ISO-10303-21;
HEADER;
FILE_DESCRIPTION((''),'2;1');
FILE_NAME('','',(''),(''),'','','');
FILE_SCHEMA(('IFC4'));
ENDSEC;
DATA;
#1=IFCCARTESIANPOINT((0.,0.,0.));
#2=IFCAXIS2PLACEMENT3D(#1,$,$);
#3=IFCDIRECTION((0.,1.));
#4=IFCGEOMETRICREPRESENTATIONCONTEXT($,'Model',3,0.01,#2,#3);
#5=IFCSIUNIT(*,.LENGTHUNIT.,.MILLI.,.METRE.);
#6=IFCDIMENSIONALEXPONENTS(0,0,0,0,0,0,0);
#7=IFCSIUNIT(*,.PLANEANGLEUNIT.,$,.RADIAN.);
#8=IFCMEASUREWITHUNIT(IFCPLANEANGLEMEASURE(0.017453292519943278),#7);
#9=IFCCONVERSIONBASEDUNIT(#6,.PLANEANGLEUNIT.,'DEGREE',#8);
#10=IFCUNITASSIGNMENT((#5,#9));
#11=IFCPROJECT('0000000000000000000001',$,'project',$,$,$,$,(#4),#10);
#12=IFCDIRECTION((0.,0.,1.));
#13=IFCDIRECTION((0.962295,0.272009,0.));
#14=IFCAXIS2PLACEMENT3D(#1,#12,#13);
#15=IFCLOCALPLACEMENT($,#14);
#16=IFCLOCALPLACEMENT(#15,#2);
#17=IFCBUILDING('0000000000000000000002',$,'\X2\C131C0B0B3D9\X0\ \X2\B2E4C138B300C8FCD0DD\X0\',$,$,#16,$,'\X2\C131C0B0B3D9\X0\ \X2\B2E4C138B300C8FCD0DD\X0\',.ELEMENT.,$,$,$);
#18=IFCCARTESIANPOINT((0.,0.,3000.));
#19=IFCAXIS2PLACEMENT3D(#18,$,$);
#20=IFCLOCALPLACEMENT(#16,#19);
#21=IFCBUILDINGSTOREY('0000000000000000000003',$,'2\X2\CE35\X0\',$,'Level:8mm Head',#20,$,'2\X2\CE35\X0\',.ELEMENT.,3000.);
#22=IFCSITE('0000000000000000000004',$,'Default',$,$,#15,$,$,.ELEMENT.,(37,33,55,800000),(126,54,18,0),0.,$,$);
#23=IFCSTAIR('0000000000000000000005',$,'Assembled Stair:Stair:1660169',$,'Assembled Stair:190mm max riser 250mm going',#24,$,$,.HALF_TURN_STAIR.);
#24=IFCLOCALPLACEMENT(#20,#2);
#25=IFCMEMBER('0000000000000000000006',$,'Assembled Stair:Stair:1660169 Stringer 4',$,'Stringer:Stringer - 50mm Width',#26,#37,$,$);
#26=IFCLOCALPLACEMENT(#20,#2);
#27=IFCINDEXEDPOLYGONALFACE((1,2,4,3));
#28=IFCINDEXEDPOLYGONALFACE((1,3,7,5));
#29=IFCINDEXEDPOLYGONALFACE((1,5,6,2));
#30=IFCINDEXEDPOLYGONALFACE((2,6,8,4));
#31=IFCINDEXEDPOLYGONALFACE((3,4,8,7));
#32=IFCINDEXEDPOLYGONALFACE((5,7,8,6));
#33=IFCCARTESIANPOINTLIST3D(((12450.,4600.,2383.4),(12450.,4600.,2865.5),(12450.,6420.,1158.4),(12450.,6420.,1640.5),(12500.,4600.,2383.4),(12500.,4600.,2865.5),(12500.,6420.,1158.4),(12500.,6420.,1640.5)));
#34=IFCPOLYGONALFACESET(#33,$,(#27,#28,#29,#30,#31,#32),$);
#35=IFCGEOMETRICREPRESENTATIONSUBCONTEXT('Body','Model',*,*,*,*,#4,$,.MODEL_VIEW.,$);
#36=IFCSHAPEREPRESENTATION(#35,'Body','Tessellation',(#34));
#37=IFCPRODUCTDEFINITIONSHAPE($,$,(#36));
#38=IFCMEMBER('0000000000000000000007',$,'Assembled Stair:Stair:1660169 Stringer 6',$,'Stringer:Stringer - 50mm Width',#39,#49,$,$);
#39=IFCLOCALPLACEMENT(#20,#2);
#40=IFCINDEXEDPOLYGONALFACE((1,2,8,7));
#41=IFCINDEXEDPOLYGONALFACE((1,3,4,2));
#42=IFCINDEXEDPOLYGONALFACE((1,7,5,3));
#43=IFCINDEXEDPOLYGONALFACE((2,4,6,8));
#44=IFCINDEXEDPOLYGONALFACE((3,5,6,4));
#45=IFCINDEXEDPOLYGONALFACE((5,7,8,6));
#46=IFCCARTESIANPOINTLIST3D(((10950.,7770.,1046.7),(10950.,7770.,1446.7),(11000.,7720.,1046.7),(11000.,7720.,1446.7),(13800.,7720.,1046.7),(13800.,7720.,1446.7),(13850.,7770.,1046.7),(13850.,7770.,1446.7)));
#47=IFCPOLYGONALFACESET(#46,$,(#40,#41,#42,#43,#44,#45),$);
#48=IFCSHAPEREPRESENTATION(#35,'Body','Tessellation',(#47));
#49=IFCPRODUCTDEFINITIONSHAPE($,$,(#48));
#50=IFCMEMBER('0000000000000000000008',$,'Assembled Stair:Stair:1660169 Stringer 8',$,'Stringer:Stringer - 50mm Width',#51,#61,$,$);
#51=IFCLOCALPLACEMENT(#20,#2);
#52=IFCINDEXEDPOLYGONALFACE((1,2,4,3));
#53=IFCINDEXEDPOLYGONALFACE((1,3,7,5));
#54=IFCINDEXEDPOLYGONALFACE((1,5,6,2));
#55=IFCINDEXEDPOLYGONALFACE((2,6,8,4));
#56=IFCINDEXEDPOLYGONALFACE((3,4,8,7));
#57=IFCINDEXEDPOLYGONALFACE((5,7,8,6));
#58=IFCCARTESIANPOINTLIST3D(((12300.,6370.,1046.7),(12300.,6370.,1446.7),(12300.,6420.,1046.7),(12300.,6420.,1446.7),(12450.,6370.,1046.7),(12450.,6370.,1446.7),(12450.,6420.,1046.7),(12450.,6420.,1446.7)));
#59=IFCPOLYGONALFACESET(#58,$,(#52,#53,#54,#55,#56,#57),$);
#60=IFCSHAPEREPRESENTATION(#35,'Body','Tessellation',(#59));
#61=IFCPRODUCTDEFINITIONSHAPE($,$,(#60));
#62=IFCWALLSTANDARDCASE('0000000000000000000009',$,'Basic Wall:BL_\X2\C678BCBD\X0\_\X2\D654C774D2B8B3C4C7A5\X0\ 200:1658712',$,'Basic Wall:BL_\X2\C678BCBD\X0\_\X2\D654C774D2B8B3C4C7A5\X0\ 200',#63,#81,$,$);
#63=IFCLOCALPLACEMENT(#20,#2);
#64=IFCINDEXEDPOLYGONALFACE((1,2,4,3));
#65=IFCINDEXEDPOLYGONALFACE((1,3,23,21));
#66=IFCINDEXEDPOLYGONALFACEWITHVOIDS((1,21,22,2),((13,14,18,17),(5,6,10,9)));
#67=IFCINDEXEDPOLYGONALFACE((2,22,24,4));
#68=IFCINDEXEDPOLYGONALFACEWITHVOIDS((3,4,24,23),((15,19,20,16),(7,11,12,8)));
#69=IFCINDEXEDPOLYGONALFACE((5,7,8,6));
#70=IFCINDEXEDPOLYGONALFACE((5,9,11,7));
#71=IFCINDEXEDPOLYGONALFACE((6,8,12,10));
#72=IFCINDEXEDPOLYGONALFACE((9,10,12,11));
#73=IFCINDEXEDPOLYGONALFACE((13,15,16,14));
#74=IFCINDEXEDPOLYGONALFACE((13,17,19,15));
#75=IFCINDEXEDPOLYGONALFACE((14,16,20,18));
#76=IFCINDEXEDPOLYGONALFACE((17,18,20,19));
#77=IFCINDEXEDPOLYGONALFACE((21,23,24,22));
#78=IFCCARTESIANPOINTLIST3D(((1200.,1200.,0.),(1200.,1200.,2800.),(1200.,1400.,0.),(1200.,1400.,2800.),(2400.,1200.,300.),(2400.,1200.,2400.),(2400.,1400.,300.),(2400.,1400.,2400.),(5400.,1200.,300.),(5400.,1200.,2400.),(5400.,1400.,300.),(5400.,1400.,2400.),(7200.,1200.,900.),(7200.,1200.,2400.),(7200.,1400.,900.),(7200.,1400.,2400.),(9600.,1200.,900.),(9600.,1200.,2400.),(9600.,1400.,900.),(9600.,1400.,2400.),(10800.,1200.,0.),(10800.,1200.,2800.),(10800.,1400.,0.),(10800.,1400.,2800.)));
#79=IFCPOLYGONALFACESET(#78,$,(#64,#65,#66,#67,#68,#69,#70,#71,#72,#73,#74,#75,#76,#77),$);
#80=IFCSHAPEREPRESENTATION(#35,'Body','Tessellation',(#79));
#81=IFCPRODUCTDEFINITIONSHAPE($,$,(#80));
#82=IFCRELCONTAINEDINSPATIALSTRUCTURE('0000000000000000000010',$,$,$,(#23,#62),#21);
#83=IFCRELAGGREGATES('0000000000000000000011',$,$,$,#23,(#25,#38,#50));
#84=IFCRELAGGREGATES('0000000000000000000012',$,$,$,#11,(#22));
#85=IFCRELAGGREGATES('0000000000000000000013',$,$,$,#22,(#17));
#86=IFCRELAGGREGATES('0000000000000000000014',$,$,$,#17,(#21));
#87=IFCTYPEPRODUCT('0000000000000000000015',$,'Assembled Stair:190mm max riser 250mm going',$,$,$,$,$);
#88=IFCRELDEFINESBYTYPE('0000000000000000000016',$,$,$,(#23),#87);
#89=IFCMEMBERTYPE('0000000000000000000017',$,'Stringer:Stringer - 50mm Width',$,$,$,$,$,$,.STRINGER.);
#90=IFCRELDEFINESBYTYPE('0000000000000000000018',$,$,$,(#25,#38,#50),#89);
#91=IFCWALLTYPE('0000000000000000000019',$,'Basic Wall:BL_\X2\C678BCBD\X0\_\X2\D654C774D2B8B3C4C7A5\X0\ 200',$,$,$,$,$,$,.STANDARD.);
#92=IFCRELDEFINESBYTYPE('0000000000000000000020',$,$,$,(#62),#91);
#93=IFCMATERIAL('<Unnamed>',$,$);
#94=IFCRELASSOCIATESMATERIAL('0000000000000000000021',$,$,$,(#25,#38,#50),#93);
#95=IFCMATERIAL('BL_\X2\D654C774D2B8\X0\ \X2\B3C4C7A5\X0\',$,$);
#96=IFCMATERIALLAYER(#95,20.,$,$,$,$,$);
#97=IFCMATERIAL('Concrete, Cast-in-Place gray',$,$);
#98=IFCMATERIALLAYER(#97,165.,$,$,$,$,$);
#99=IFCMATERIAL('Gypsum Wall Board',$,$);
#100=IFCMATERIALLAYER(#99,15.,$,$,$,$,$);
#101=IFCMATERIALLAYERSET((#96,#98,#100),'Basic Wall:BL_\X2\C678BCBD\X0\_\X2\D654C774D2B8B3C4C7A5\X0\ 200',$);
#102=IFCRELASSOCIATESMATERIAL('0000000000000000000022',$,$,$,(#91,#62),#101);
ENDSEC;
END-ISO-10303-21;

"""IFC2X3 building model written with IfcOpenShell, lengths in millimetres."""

from ifc_helpers import new_model, entity, si_unit, converted_unit, direction, frame, frame_2d, origin, origin_2d_with_axis, place, context, subcontext, project, spatial, polyline, rectangle, outline, extrude, material, layer, layer_set, layer_usage, type_object, element, aggregate, save


model = new_model("IFC2X3")

# Units and contexts
model_context = context("Model", 3, precision=0.01, world=origin(), true_north=direction((0.0, 1.0)))
body_context = subcontext(model_context, "Body", "Model", "MODEL_VIEW")
ifc_project = project(units=[si_unit("LENGTHUNIT", "METRE", prefix="MILLI"), converted_unit("PLANEANGLEUNIT", "DEGREE", entity("IfcPlaneAngleMeasure", 0.017453292519943278), si_unit("PLANEANGLEUNIT", "RADIAN"), dimensions=[0, 0, 0, 0, 0, 0, 0])], contexts=[model_context])

# Site, building, storey
site_placement = place(None, frame((0.0, 0.0, 0.0), z_axis=(0.0, 0.0, 1.0), x_axis=(0.962295, 0.272009, 0.0)))
site = spatial("IfcSite", under=ifc_project, at=site_placement, Name="Default", CompositionType="ELEMENT", RefLatitude=(37, 33, 55, 800000), RefLongitude=(126, 54, 18, 0), RefElevation=0.0)
building_placement = place(site_placement, origin())
building = spatial("IfcBuilding", under=site, at=building_placement, Name="성산동 다세대주택", LongName="성산동 다세대주택", CompositionType="ELEMENT")
storey_placement = place(building_placement, frame((0.0, 0.0, 3000.0)))
storey = spatial("IfcBuildingStorey", under=building, at=storey_placement, Name="2층", ObjectType="Level:8mm Head", LongName="2층", CompositionType="ELEMENT", Elevation=3000.0)

# Stair, members
type_product = type_object("IfcTypeProduct", Name="Assembled Stair:190mm max riser 250mm going")
stair_placement = place(storey_placement, origin())
stair = element("IfcStair", 1, at=stair_placement, inside=storey, type_object=type_product, Name="Assembled Stair:Stair:1660169", ObjectType="Assembled Stair:190mm max riser 250mm going", ShapeType="HALF_TURN_STAIR")
ifc_material_1 = material(Name="<Unnamed>")
member_type = type_object("IfcMemberType", Name="Stringer:Stringer - 50mm Width", PredefinedType="STRINGER")
member_1_placement = place(stair_placement, origin())
member_1 = element("IfcMember", 2, at=member_1_placement, type_object=member_type, material=ifc_material_1, Name="Assembled Stair:Stair:1660169 Stringer 4", ObjectType="Stringer:Stringer - 50mm Width", context=body_context, shape_type="SweptSolid", body=[
    extrude(outline(polyline([(-962.3, -200.0), (1231.5, -200.0), (962.3, 200.0), (-1231.5, 200.0), (-962.3, -200.0)])), frame((12450.0, 5510.0, 2011.9), z_axis=(1.0, 0.0, 0.0), x_axis=(0.0, -0.829588, 0.558376)), (0.0, 0.0, 1.0), 50.0),
])
member_2_placement = place(stair_placement, origin())
member_2 = element("IfcMember", 3, at=member_2_placement, type_object=member_type, material=ifc_material_1, Name="Assembled Stair:Stair:1660169 Stringer 6", ObjectType="Stringer:Stringer - 50mm Width", context=body_context, shape_type="SweptSolid", body=[
    extrude(outline(polyline([(-1450.0, -25.0), (1450.0, -25.0), (1400.0, 25.0), (-1400.0, 25.0), (-1450.0, -25.0)])), frame((12400.0, 7745.0, 1046.7), z_axis=(0.0, 0.0, 1.0), x_axis=(-1.0, 0.0, 0.0)), (0.0, 0.0, 1.0), 400.0),
])
member_3_placement = place(stair_placement, origin())
member_3 = element("IfcMember", 4, at=member_3_placement, type_object=member_type, material=ifc_material_1, Name="Assembled Stair:Stair:1660169 Stringer 8", ObjectType="Stringer:Stringer - 50mm Width", context=body_context, shape_type="SweptSolid", body=[
    extrude(rectangle(XDim=150.0, YDim=50.0, at=origin_2d_with_axis()), frame((12375.0, 6395.0, 1046.7)), (0.0, 0.0, 1.0), 400.0),
])

# Shared definitions
ifc_material_2 = material(Name="Concrete, Cast-in-Place gray")

# Wall, openings
ifc_material_3 = material(Name="BL_화이트 도장")
ifc_layer_1 = layer(ifc_material_3, 20.0)
ifc_layer_2 = layer(ifc_material_2, 165.0)
ifc_material_4 = material(Name="Gypsum Wall Board")
ifc_layer_3 = layer(ifc_material_4, 15.0)
ifc_layer_set_1 = layer_set([ifc_layer_1, ifc_layer_2, ifc_layer_3], Name="Basic Wall:BL_외벽_화이트도장 200")
ifc_layer_usage_1 = layer_usage(ifc_layer_set_1, "AXIS2", "POSITIVE", -100.0)
wall_type = type_object("IfcWallType", Name="Basic Wall:BL_외벽_화이트도장 200", PredefinedType="STANDARD", material=ifc_layer_set_1)
wall_placement = place(storey_placement, frame((1200.0, 1300.0, 0.0)))
wall = element("IfcWallStandardCase", 5, at=wall_placement, inside=storey, type_object=wall_type, material=ifc_layer_usage_1, Name="Basic Wall:BL_외벽_화이트도장 200:1658712", ObjectType="Basic Wall:BL_외벽_화이트도장 200", context=body_context, shape_type="SweptSolid", body=[
    extrude(rectangle(XDim=9600.0, YDim=200.0, at=frame_2d((4800.0, 0.0), x_axis=(-1.0, 0.0))), origin(), (0.0, 0.0, 1.0), 2800.0),
])
opening_1_placement = place(wall_placement, frame((1200.0, -100.0, 300.0)))
element("IfcOpeningElement", 6, at=opening_1_placement, cuts=wall, ObjectType="Opening", context=body_context, shape_type="SweptSolid", body=[
    extrude(rectangle(XDim=2100.0, YDim=3000.0, at=frame_2d((1050.0, 1500.0), x_axis=(-1.0, 0.0))), frame((0.0, 0.0, 0.0), z_axis=(0.0, 1.0, 0.0), x_axis=(0.0, 0.0, 1.0)), (0.0, 0.0, 1.0), 200.0),
])
opening_2_placement = place(wall_placement, frame((6000.0, -100.0, 900.0)))
element("IfcOpeningElement", 7, at=opening_2_placement, cuts=wall, ObjectType="Opening", context=body_context, shape_type="SweptSolid", body=[
    extrude(rectangle(XDim=1500.0, YDim=2400.0, at=frame_2d((750.0, 1200.0), x_axis=(-1.0, 0.0))), frame((0.0, 0.0, 0.0), z_axis=(0.0, 1.0, 0.0), x_axis=(0.0, 0.0, 1.0)), (0.0, 0.0, 1.0), 200.0),
])

aggregate(stair, [member_1, member_2, member_3])

save(model, "model.ifc")
